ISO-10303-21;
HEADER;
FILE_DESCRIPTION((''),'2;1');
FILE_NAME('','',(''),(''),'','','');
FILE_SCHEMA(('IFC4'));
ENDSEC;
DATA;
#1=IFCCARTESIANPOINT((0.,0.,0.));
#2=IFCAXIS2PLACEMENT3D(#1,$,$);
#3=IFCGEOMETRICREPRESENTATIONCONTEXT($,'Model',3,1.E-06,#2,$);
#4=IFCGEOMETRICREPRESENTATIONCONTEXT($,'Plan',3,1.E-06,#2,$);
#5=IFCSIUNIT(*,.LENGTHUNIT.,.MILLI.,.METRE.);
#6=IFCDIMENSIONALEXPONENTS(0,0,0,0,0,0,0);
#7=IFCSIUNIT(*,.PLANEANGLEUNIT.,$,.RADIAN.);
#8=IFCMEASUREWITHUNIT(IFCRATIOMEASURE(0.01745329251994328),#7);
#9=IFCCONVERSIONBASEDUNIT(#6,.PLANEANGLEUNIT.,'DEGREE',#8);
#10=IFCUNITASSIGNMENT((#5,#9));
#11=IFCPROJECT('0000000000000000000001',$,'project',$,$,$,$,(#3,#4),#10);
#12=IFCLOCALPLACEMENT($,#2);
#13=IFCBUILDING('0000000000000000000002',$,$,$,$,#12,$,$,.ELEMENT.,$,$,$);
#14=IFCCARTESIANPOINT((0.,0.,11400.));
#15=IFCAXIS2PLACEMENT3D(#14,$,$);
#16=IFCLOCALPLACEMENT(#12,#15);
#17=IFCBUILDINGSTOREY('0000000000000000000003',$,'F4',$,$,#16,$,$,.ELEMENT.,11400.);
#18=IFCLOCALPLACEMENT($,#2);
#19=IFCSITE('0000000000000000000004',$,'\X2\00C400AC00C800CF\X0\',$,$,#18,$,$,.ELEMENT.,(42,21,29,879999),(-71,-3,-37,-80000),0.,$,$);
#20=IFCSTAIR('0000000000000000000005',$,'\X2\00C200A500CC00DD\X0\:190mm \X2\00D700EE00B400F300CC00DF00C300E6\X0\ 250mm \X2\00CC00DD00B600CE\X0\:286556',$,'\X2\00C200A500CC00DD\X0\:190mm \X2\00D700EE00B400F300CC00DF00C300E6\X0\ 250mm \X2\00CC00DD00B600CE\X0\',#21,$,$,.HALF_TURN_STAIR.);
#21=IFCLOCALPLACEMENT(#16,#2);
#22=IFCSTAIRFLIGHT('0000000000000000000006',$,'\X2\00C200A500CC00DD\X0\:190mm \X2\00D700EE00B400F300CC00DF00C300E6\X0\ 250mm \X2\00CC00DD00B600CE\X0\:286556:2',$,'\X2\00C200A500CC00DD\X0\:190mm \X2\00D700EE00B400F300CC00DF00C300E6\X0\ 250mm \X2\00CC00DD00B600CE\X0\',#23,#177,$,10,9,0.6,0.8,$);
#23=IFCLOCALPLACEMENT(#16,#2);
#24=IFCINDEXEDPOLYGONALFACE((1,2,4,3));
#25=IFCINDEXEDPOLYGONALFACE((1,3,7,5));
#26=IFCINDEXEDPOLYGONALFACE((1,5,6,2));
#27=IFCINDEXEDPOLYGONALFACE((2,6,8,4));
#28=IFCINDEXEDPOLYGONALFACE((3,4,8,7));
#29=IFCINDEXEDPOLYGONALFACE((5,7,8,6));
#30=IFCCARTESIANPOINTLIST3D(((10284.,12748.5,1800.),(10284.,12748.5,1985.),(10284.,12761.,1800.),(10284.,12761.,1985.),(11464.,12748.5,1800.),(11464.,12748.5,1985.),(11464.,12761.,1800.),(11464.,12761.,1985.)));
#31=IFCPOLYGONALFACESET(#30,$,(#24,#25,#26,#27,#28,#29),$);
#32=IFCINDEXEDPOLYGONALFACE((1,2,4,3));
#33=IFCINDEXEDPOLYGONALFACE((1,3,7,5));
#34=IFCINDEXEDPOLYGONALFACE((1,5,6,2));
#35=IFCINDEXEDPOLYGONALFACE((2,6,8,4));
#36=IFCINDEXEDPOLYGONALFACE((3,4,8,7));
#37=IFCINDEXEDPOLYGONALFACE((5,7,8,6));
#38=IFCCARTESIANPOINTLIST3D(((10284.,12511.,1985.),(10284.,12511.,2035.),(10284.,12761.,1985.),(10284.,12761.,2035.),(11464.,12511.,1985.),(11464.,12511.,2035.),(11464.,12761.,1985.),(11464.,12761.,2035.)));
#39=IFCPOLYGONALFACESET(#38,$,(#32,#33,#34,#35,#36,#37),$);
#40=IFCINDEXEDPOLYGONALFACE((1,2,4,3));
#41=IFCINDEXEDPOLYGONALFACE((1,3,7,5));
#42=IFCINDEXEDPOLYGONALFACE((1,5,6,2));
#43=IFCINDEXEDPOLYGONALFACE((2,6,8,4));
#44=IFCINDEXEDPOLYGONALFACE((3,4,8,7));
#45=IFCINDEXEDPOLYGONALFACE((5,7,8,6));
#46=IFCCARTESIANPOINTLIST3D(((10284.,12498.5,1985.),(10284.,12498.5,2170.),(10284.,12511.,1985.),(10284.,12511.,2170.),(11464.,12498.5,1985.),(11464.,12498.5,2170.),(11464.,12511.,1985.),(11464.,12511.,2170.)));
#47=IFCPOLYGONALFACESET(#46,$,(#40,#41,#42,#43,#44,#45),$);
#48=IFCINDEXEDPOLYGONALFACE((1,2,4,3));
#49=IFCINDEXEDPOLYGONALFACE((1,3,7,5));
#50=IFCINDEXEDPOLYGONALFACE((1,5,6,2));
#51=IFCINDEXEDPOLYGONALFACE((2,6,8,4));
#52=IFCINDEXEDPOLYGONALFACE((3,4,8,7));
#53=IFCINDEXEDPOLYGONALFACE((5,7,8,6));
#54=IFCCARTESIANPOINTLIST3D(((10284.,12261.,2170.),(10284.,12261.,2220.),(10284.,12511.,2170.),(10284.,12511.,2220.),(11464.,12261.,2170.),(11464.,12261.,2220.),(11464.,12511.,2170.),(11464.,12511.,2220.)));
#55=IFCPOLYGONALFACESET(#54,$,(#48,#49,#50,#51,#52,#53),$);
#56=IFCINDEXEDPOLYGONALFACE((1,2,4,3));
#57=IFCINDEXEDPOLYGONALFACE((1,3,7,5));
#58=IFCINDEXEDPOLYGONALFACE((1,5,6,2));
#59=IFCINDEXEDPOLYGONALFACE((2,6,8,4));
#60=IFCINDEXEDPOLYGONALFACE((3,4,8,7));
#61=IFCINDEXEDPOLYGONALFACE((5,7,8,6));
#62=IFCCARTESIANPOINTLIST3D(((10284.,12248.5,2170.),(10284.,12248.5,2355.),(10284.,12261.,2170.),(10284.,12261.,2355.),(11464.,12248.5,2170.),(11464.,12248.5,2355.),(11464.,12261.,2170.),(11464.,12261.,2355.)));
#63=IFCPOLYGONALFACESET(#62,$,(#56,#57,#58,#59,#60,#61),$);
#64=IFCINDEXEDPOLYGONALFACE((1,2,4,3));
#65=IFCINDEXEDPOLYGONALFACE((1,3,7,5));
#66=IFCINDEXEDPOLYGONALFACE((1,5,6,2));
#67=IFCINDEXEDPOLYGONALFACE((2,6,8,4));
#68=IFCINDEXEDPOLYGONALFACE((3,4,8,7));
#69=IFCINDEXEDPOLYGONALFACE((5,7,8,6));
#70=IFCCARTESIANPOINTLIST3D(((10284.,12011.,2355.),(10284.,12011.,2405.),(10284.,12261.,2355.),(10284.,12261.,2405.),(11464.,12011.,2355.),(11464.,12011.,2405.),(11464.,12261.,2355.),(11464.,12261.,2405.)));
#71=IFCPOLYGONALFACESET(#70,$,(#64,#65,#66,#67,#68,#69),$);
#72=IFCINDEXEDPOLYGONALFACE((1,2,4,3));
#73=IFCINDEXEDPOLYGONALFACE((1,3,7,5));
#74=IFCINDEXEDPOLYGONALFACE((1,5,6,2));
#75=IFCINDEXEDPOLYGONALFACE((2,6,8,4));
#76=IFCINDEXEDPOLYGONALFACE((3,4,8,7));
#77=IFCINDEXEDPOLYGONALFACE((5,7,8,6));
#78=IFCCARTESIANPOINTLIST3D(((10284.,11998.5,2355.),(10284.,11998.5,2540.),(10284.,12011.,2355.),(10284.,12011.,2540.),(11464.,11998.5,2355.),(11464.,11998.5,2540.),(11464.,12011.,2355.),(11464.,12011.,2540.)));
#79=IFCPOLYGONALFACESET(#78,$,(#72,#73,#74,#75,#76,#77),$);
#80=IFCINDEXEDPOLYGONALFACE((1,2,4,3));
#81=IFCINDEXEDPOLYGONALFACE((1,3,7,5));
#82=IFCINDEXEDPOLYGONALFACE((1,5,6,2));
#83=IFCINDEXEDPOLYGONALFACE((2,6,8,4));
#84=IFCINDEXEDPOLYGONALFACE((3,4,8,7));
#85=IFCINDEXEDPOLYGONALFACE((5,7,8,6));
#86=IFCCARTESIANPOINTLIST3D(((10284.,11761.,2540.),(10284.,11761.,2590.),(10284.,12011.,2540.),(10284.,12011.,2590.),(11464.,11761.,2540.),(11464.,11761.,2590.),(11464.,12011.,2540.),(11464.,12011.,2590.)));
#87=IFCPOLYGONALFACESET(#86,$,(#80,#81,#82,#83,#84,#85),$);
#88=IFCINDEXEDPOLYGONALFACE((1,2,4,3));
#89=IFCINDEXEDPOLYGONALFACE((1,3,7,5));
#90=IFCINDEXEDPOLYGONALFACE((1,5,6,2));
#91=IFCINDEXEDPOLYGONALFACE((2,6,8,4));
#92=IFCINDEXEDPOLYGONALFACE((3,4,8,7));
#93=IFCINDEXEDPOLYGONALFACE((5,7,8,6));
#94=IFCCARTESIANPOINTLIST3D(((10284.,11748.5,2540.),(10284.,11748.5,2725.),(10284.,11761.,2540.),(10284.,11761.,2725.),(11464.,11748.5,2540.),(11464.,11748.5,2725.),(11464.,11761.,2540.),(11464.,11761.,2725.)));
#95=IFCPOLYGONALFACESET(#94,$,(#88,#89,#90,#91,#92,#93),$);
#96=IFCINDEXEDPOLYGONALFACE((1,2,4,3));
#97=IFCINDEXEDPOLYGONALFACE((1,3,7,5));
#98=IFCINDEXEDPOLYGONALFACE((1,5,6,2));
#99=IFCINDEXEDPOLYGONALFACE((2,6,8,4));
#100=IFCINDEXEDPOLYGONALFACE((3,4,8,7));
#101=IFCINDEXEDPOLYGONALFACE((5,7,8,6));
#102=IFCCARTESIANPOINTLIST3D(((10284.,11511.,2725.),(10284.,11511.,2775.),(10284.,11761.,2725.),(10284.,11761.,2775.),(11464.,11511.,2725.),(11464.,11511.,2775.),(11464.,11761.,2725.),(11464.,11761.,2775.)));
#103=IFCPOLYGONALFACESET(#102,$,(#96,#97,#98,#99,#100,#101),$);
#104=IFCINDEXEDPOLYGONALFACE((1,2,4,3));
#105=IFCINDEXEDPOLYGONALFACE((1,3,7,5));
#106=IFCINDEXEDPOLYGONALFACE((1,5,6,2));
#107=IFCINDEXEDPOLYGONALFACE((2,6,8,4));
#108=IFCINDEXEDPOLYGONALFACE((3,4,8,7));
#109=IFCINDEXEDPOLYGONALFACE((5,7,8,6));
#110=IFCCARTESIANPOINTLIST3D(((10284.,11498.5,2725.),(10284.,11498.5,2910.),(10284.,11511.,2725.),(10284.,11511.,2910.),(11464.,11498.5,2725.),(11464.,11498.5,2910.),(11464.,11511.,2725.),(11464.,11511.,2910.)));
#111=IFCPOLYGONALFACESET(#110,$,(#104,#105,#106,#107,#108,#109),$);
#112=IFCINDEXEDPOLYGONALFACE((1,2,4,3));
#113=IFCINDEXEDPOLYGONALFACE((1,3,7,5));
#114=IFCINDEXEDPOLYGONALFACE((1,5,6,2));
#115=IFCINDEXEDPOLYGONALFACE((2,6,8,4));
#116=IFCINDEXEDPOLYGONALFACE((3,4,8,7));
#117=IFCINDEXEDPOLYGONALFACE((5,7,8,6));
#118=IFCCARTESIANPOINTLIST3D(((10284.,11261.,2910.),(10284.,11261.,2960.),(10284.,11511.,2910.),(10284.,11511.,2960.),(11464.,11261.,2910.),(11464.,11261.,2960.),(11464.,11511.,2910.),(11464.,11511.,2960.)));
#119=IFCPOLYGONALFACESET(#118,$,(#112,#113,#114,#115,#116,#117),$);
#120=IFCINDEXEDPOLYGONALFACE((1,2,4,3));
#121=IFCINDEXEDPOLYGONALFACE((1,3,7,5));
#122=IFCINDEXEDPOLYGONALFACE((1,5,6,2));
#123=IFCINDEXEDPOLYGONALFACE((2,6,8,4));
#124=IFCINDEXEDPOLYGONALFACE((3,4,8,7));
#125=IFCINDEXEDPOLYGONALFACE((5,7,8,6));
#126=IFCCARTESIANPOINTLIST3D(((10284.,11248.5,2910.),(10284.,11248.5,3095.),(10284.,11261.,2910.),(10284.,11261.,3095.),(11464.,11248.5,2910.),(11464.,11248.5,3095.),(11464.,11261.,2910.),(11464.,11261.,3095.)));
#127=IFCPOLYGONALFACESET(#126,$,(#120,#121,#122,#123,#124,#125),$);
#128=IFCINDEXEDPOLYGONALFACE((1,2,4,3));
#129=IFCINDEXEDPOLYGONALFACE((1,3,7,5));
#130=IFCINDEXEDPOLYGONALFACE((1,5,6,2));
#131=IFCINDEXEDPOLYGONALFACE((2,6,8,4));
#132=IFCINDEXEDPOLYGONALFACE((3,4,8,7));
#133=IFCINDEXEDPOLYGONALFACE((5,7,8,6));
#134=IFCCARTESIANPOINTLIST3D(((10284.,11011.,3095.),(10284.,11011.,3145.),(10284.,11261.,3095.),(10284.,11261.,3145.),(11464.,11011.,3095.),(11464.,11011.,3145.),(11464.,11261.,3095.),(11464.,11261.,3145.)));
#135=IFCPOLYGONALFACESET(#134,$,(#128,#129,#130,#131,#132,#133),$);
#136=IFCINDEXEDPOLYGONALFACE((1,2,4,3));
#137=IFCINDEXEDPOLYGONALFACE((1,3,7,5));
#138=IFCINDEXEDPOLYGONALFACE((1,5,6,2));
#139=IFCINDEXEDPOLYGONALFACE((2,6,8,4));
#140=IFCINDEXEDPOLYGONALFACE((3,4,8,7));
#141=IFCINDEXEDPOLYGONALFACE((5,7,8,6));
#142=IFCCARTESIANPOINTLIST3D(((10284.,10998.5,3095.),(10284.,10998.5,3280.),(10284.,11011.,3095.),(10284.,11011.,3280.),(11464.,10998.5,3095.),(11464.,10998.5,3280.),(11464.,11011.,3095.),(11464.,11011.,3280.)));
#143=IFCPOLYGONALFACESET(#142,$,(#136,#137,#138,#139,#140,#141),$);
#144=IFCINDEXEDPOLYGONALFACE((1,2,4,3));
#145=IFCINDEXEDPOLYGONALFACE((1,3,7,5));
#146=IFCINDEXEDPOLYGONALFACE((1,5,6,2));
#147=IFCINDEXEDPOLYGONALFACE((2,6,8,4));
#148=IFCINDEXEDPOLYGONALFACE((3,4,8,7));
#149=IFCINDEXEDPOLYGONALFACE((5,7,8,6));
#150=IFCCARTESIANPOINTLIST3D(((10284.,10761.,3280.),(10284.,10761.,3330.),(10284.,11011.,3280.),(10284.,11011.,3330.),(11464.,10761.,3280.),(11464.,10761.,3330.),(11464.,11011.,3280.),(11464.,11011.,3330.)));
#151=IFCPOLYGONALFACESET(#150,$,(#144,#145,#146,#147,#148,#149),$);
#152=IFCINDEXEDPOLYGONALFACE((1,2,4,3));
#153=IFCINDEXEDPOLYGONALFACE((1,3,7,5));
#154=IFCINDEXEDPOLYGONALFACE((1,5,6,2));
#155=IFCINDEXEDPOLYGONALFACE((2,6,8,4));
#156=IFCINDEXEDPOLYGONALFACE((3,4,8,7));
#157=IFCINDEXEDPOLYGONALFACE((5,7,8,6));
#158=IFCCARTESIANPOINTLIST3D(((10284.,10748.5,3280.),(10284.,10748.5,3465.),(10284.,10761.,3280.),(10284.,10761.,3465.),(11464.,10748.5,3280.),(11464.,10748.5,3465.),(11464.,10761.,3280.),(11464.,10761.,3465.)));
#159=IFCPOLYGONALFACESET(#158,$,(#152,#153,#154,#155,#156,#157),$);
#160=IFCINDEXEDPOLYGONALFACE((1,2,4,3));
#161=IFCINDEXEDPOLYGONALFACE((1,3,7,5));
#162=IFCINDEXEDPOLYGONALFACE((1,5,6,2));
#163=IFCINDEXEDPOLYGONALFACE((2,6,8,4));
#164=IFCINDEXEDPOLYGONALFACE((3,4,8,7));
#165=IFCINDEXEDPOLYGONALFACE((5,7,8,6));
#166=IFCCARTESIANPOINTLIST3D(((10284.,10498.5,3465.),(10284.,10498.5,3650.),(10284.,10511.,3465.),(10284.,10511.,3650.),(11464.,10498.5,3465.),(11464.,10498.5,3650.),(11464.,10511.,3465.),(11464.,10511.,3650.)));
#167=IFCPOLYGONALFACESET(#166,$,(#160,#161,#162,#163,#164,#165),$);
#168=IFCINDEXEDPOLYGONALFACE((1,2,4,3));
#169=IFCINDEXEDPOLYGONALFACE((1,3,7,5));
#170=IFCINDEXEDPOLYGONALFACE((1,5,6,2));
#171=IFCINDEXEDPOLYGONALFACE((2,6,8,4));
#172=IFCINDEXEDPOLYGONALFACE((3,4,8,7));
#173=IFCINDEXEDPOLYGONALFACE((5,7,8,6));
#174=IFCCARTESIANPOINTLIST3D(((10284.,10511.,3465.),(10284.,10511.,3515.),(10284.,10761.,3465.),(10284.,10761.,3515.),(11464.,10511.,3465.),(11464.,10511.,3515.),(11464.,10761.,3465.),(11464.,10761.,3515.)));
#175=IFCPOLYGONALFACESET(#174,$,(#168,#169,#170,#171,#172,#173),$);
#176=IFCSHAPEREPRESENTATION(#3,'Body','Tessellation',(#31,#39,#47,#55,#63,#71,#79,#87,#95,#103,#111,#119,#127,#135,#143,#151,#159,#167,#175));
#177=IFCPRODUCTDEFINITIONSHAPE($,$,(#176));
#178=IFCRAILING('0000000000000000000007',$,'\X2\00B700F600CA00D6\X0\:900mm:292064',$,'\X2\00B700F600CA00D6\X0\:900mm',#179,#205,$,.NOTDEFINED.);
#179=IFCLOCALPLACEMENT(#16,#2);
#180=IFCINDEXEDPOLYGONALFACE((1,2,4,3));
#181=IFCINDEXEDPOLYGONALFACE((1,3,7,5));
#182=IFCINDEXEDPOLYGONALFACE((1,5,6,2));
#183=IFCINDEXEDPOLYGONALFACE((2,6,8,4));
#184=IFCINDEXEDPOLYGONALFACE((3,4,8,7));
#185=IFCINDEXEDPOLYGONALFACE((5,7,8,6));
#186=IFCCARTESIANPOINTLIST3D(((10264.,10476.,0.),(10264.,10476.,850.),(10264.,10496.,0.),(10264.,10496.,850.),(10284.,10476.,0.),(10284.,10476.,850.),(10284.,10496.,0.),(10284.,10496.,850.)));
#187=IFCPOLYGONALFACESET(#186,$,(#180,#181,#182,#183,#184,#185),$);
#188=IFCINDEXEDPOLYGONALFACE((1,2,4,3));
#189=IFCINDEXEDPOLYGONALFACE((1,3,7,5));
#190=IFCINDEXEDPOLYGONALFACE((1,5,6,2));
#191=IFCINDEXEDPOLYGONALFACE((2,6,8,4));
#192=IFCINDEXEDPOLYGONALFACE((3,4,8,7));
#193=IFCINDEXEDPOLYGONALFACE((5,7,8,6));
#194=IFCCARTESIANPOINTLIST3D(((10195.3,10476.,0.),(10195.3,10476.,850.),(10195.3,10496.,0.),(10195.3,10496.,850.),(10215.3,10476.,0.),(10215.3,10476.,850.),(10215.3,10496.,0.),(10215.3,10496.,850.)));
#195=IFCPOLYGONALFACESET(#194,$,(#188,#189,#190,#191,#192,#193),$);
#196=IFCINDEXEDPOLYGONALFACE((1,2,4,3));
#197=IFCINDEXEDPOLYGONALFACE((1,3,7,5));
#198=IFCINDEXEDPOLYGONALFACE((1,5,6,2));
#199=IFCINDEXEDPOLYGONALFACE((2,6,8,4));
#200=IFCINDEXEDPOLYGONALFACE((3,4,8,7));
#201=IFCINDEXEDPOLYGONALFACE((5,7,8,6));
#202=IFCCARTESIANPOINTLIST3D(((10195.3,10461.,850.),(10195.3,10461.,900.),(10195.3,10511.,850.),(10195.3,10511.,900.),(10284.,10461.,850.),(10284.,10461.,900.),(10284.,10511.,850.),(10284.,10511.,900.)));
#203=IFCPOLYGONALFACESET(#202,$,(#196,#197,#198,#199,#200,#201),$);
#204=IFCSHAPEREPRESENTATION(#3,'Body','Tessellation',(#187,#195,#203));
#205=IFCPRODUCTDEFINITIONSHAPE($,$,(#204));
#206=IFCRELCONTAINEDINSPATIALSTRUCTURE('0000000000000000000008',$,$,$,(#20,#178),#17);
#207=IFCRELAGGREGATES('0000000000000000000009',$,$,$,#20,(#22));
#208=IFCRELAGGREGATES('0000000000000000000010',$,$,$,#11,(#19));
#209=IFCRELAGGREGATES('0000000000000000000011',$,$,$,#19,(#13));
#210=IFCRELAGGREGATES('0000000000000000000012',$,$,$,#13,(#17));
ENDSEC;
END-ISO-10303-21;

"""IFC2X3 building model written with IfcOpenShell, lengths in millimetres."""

from ifc_helpers import new_model, entity, si_unit, converted_unit, frame, origin, origin_2d_with_axis, place, context, project, spatial, rectangle, extrude, element, aggregate, save


model = new_model("IFC2X3")

# Units and contexts
model_context = context("Model", 3, precision=1e-06, world=origin())
plan_context = context("Plan", 3, precision=1e-06, world=origin())
ifc_project = project(units=[si_unit("LENGTHUNIT", "METRE", prefix="MILLI"), converted_unit("PLANEANGLEUNIT", "DEGREE", entity("IfcRatioMeasure", 0.01745329251994328), si_unit("PLANEANGLEUNIT", "RADIAN"), dimensions=[0, 0, 0, 0, 0, 0, 0])], contexts=[model_context, plan_context])

# Site, building, storey
site_placement = place(None, origin())
site = spatial("IfcSite", under=ifc_project, at=site_placement, Name="Ä¬ÈÏ", CompositionType="ELEMENT", RefLatitude=(42, 21, 29, 879999), RefLongitude=(-71, -3, -37, -80000), RefElevation=0.0)
building_placement = place(None, origin())
building = spatial("IfcBuilding", under=site, at=building_placement, CompositionType="ELEMENT")
storey_placement = place(building_placement, frame((0.0, 0.0, 11400.0)))
storey = spatial("IfcBuildingStorey", under=building, at=storey_placement, Name="F4", CompositionType="ELEMENT", Elevation=11400.0)

# Stair
stair_1_placement = place(storey_placement, origin())
stair_1 = element("IfcStair", 1, at=stair_1_placement, inside=storey, Name="Â¥ÌÝ:190mm ×î´óÌßÃæ 250mm ÌÝ¶Î:286556", ObjectType="Â¥ÌÝ:190mm ×î´óÌßÃæ 250mm ÌÝ¶Î", ShapeType="HALF_TURN_STAIR")

# Stair flight
stair_flight_1_placement = place(storey_placement, origin())
stair_flight_1 = element("IfcStairFlight", 2, at=stair_flight_1_placement, Name="Â¥ÌÝ:190mm ×î´óÌßÃæ 250mm ÌÝ¶Î:286556:2", ObjectType="Â¥ÌÝ:190mm ×î´óÌßÃæ 250mm ÌÝ¶Î", NumberOfRiser=10, NumberOfTreads=9, RiserHeight=0.6, TreadLength=0.8, context=model_context, shape_type="SweptSolid", body=[
    extrude(rectangle(XDim=1180.0, YDim=12.5, at=origin_2d_with_axis()), frame((10874.0, 12754.8, 1800.0)), (0.0, 0.0, 1.0), 185.0),
    extrude(rectangle(XDim=250.0, YDim=1180.0, at=origin_2d_with_axis()), frame((10874.0, 12636.0, 1985.0), z_axis=(0.0, 0.0, 1.0), x_axis=(0.0, 1.0, 0.0)), (0.0, 0.0, 1.0), 50.0),
    extrude(rectangle(XDim=1180.0, YDim=12.5, at=origin_2d_with_axis()), frame((10874.0, 12504.8, 1985.0)), (0.0, 0.0, 1.0), 185.0),
    extrude(rectangle(XDim=250.0, YDim=1180.0, at=origin_2d_with_axis()), frame((10874.0, 12386.0, 2170.0), z_axis=(0.0, 0.0, 1.0), x_axis=(0.0, 1.0, 0.0)), (0.0, 0.0, 1.0), 50.0),
    extrude(rectangle(XDim=1180.0, YDim=12.5, at=origin_2d_with_axis()), frame((10874.0, 12254.8, 2170.0)), (0.0, 0.0, 1.0), 185.0),
    extrude(rectangle(XDim=250.0, YDim=1180.0, at=origin_2d_with_axis()), frame((10874.0, 12136.0, 2355.0), z_axis=(0.0, 0.0, 1.0), x_axis=(0.0, 1.0, 0.0)), (0.0, 0.0, 1.0), 50.0),
    extrude(rectangle(XDim=1180.0, YDim=12.5, at=origin_2d_with_axis()), frame((10874.0, 12004.8, 2355.0)), (0.0, 0.0, 1.0), 185.0),
    extrude(rectangle(XDim=250.0, YDim=1180.0, at=origin_2d_with_axis()), frame((10874.0, 11886.0, 2540.0), z_axis=(0.0, 0.0, 1.0), x_axis=(0.0, 1.0, 0.0)), (0.0, 0.0, 1.0), 50.0),
    extrude(rectangle(XDim=1180.0, YDim=12.5, at=origin_2d_with_axis()), frame((10874.0, 11754.8, 2540.0)), (0.0, 0.0, 1.0), 185.0),
    extrude(rectangle(XDim=250.0, YDim=1180.0, at=origin_2d_with_axis()), frame((10874.0, 11636.0, 2725.0), z_axis=(0.0, 0.0, 1.0), x_axis=(0.0, 1.0, 0.0)), (0.0, 0.0, 1.0), 50.0),
    extrude(rectangle(XDim=1180.0, YDim=12.5, at=origin_2d_with_axis()), frame((10874.0, 11504.8, 2725.0)), (0.0, 0.0, 1.0), 185.0),
    extrude(rectangle(XDim=250.0, YDim=1180.0, at=origin_2d_with_axis()), frame((10874.0, 11386.0, 2910.0), z_axis=(0.0, 0.0, 1.0), x_axis=(0.0, 1.0, 0.0)), (0.0, 0.0, 1.0), 50.0),
    extrude(rectangle(XDim=1180.0, YDim=12.5, at=origin_2d_with_axis()), frame((10874.0, 11254.8, 2910.0)), (0.0, 0.0, 1.0), 185.0),
    extrude(rectangle(XDim=250.0, YDim=1180.0, at=origin_2d_with_axis()), frame((10874.0, 11136.0, 3095.0), z_axis=(0.0, 0.0, 1.0), x_axis=(0.0, 1.0, 0.0)), (0.0, 0.0, 1.0), 50.0),
    extrude(rectangle(XDim=1180.0, YDim=12.5, at=origin_2d_with_axis()), frame((10874.0, 11004.8, 3095.0)), (0.0, 0.0, 1.0), 185.0),
    extrude(rectangle(XDim=250.0, YDim=1180.0, at=origin_2d_with_axis()), frame((10874.0, 10886.0, 3280.0), z_axis=(0.0, 0.0, 1.0), x_axis=(0.0, 1.0, 0.0)), (0.0, 0.0, 1.0), 50.0),
    extrude(rectangle(XDim=1180.0, YDim=12.5, at=origin_2d_with_axis()), frame((10874.0, 10754.8, 3280.0)), (0.0, 0.0, 1.0), 185.0),
    extrude(rectangle(XDim=1180.0, YDim=12.5, at=origin_2d_with_axis()), frame((10874.0, 10504.8, 3465.0)), (0.0, 0.0, 1.0), 185.0),
    extrude(rectangle(XDim=250.0, YDim=1180.0, at=origin_2d_with_axis()), frame((10874.0, 10636.0, 3465.0), z_axis=(0.0, 0.0, 1.0), x_axis=(0.0, 1.0, 0.0)), (0.0, 0.0, 1.0), 50.0),
])

# Railing
railing_1_placement = place(storey_placement, origin())
element("IfcRailing", 3, at=railing_1_placement, inside=storey, Name="·öÊÖ:900mm:292064", ObjectType="·öÊÖ:900mm", PredefinedType="NOTDEFINED", context=model_context, shape_type="SweptSolid", body=[
    extrude(rectangle(XDim=20.0, YDim=20.0, at=origin_2d_with_axis()), frame((10274.0, 10486.0, 0.0)), (0.0, 0.0, 1.0), 850.0),
    extrude(rectangle(XDim=20.0, YDim=20.0, at=origin_2d_with_axis()), frame((10205.3, 10486.0, 0.0)), (0.0, 0.0, 1.0), 850.0),
    extrude(rectangle(XDim=88.7, YDim=50.0, at=origin_2d_with_axis()), frame((10239.6, 10486.0, 850.0)), (0.0, 0.0, 1.0), 50.0),
])

aggregate(stair_1, [stair_flight_1])

save(model, "model.ifc")
